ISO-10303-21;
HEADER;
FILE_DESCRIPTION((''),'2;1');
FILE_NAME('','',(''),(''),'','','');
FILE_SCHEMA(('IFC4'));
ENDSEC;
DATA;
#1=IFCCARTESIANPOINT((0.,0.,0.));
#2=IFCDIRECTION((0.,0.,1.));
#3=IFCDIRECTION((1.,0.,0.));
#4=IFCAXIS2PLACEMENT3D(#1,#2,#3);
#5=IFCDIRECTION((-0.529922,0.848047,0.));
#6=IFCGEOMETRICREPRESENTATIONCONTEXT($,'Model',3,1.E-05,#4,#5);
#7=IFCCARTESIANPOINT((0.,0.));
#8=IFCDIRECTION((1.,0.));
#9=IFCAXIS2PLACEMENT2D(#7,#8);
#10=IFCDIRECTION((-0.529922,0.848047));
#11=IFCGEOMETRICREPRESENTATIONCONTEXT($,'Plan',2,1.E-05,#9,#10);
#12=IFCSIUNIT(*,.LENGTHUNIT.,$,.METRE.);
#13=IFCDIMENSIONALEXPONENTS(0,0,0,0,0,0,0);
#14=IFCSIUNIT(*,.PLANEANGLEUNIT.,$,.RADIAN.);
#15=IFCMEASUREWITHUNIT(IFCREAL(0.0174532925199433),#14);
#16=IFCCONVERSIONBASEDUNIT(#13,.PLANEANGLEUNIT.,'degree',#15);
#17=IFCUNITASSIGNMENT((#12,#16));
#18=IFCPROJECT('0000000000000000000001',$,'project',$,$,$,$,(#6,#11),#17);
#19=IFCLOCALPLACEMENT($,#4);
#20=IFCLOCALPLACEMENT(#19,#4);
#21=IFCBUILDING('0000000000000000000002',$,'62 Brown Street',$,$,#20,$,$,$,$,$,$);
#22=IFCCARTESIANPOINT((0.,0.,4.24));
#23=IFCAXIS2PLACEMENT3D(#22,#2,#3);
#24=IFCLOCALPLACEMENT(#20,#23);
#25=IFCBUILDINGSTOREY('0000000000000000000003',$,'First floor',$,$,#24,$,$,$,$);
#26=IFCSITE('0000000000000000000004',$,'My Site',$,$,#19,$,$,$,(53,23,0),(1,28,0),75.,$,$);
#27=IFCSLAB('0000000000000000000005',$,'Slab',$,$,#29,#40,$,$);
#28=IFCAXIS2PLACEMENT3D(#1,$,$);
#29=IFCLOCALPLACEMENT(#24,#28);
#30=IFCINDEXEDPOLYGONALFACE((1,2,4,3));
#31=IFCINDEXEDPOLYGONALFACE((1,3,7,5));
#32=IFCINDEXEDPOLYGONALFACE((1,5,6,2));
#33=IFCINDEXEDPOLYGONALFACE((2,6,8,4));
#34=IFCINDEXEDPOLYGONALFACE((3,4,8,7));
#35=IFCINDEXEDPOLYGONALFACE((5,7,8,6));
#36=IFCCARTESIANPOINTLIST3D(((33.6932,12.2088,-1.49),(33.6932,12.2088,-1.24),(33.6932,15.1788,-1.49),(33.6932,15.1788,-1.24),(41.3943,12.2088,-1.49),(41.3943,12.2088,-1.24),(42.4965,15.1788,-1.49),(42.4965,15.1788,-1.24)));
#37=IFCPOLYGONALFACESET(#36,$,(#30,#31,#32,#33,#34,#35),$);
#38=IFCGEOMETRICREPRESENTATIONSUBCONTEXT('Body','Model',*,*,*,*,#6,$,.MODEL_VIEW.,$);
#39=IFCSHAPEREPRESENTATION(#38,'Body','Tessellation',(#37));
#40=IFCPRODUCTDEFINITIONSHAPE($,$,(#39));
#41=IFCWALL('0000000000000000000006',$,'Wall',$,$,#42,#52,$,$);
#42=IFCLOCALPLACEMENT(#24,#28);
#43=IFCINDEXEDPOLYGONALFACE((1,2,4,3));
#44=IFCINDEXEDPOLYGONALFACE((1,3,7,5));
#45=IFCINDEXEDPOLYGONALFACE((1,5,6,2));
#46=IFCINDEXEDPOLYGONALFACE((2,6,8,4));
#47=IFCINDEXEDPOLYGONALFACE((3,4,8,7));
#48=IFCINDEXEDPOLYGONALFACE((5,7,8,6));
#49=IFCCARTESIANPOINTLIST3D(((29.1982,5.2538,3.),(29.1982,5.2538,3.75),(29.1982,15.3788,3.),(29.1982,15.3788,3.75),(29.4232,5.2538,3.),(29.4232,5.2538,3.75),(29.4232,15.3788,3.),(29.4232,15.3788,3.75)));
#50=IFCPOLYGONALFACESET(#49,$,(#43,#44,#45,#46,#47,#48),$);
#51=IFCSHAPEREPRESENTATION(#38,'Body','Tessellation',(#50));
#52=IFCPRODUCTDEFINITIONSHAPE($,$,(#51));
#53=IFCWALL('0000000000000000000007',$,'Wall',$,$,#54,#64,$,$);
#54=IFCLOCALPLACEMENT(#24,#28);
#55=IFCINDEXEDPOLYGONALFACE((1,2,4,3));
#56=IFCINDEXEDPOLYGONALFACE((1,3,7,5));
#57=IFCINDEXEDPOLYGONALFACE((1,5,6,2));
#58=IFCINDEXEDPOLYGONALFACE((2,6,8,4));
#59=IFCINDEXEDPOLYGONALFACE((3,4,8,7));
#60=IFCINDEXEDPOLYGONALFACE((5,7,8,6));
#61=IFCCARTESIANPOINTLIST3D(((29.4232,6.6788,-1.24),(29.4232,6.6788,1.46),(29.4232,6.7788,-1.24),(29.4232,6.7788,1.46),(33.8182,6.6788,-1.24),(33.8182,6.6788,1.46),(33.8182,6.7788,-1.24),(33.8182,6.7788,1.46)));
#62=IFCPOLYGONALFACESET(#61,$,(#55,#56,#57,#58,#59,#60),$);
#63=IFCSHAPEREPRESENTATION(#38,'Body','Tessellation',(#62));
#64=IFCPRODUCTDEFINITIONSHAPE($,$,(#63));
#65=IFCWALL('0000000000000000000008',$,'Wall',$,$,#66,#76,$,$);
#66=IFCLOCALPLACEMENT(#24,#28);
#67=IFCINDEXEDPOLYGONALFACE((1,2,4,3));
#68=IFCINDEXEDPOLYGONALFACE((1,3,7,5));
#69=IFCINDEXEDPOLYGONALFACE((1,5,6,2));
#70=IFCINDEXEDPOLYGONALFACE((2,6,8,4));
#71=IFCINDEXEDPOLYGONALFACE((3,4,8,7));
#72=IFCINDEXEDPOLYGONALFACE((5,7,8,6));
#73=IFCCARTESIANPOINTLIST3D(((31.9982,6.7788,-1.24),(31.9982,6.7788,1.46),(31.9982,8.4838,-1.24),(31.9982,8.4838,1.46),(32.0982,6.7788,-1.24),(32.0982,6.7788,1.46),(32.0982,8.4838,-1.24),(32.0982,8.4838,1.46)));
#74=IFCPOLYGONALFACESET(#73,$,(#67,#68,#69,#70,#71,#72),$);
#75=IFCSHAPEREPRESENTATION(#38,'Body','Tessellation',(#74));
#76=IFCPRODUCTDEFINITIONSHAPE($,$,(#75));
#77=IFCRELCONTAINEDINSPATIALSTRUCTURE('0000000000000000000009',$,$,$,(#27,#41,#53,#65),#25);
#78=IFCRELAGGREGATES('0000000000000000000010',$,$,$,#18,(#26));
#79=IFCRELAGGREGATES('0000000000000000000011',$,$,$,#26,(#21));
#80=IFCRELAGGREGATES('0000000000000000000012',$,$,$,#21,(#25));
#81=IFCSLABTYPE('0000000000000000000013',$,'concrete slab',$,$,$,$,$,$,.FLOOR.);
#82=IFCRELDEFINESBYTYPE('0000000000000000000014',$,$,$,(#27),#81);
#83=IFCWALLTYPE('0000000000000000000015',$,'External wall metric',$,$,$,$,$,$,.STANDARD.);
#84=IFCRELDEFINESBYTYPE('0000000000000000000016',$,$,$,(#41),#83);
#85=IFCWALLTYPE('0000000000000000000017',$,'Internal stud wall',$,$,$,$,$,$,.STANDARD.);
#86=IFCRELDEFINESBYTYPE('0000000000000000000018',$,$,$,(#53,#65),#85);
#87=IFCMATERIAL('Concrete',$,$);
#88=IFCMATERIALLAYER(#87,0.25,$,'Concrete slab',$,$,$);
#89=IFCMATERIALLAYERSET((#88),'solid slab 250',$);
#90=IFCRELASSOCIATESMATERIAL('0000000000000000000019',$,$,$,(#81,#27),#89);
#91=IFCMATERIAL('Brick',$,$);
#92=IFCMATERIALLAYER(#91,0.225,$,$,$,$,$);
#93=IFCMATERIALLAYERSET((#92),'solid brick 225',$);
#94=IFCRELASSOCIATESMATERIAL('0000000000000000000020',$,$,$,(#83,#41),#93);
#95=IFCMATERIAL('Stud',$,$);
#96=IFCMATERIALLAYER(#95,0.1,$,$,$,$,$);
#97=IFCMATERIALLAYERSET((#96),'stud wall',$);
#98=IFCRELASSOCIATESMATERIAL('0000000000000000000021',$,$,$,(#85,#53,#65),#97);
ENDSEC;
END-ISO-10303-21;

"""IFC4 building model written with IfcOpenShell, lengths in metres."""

from ifc_helpers import new_model, entity, si_unit, converted_unit, direction, frame, origin_with_axes, origin_2d_with_axis, place, context, subcontext, project, spatial, line, indexed_curve, outline, extrude, material, layer, layer_set, layer_usage, type_object, element, save


model = new_model("IFC4")

# Units and contexts
model_context = context("Model", 3, precision=1e-05, world=origin_with_axes(), true_north=direction((-0.529922, 0.848047, 0.0)))
plan_context = context("Plan", 2, precision=1e-05, world=origin_2d_with_axis(), true_north=direction((-0.529922, 0.848047)))
body_context_1 = subcontext(model_context, "Body", "Model", "MODEL_VIEW")
ifc_project = project(units=[si_unit("LENGTHUNIT", "METRE"), converted_unit("PLANEANGLEUNIT", "degree", entity("IfcReal", 0.0174532925199433), si_unit("PLANEANGLEUNIT", "RADIAN"), dimensions=[0, 0, 0, 0, 0, 0, 0])], contexts=[model_context, plan_context])

# Site, building, storey
site_placement = place(None, origin_with_axes())
site = spatial("IfcSite", under=ifc_project, at=site_placement, Name="My Site", RefLatitude=(53, 23, 0), RefLongitude=(1, 28, 0), RefElevation=75.0)
building_placement = place(site_placement, origin_with_axes())
building = spatial("IfcBuilding", under=site, at=building_placement, Name="62 Brown Street")
storey_placement = place(building_placement, frame((0.0, 0.0, 4.24), z_axis=(0.0, 0.0, 1.0), x_axis=(1.0, 0.0, 0.0)))
storey = spatial("IfcBuildingStorey", under=building, at=storey_placement, Name="First floor")

# Shared definitions
ifc_material_1 = material(Name="Concrete")

# Slab
ifc_layer_1 = layer(ifc_material_1, 0.25, Name="Concrete slab")
ifc_layer_set_1 = layer_set([ifc_layer_1], Name="solid slab 250")
ifc_layer_usage_1 = layer_usage(ifc_layer_set_1, "AXIS3", "POSITIVE", 0.0)
slab_type = type_object("IfcSlabType", Name="concrete slab", PredefinedType="FLOOR", material=ifc_layer_set_1)
slab_1_placement = place(storey_placement, frame((33.6932, 12.2088, -1.49), z_axis=(0.0, 0.0, 1.0), x_axis=(1.0, 0.0, 0.0)))
element("IfcSlab", 1, at=slab_1_placement, inside=storey, type_object=slab_type, material=ifc_layer_usage_1, Name="Slab", context=body_context_1, shape_type="SweptSolid", body=[
    extrude(outline(indexed_curve([(8.8033, 2.97), (7.7011, 0.0), (0.0, 0.0), (0.0, 2.97)], segments=[line(4, 1), line(1, 2), line(2, 3), line(3, 4)], self_intersect=False)), None, (0.0, 0.0, 1.0), 0.25),
])

# Shared definitions
ifc_material_2 = material(Name="Brick")
ifc_layer_2 = layer(ifc_material_2, 0.225)
ifc_layer_set_2 = layer_set([ifc_layer_2], Name="solid brick 225")
wall_type_1 = type_object("IfcWallType", Name="External wall metric", PredefinedType="STANDARD", material=ifc_layer_set_2)

# Wall
ifc_layer_usage_2 = layer_usage(ifc_layer_set_2, "AXIS2", "POSITIVE", 0.0)
wall_1_placement = place(storey_placement, frame((29.4232, 5.2538, 3.0), z_axis=(0.0, 0.0, 1.0), x_axis=(0.0, 1.0, 0.0)))
element("IfcWall", 2, at=wall_1_placement, inside=storey, type_object=wall_type_1, material=ifc_layer_usage_2, Name="Wall", context=body_context_1, shape_type="SweptSolid", body=[
    extrude(outline(indexed_curve([(0.0, 0.0), (0.0, 0.225), (10.125, 0.225), (10.125, 0.0), (0.0, 0.0)], self_intersect=False)), origin_with_axes(), (0.0, 0.0, 1.0), 0.75),
])

# Shared definitions
ifc_material_3 = material(Name="Stud")
ifc_layer_3 = layer(ifc_material_3, 0.1)
ifc_layer_set_3 = layer_set([ifc_layer_3], Name="stud wall")
wall_type_2 = type_object("IfcWallType", Name="Internal stud wall", PredefinedType="STANDARD", material=ifc_layer_set_3)

# Walls
ifc_layer_usage_3 = layer_usage(ifc_layer_set_3, "AXIS2", "POSITIVE", 0.0)
wall_2_placement = place(storey_placement, frame((33.8182, 6.7788, -1.24), z_axis=(0.0, 0.0, 1.0), x_axis=(-1.0, 0.000001, 0.0)))
element("IfcWall", 3, at=wall_2_placement, inside=storey, type_object=wall_type_2, material=ifc_layer_usage_3, Name="Wall", context=body_context_1, shape_type="SweptSolid", body=[
    extrude(outline(indexed_curve([(0.0, 0.0), (0.0, 0.1), (4.395, 0.1), (4.395, 0.0), (0.0, 0.0)], self_intersect=False)), origin_with_axes(), (0.0, 0.0, 1.0), 2.7),
])
ifc_layer_usage_4 = layer_usage(ifc_layer_set_3, "AXIS2", "POSITIVE", 0.0)
wall_3_placement = place(storey_placement, frame((32.0982, 6.7788, -1.24), z_axis=(0.0, 0.0, 1.0), x_axis=(0.000001, 1.0, 0.0)))
element("IfcWall", 4, at=wall_3_placement, inside=storey, type_object=wall_type_2, material=ifc_layer_usage_4, Name="Wall", context=body_context_1, shape_type="SweptSolid", body=[
    extrude(outline(indexed_curve([(0.0, 0.0), (0.0, 0.1), (1.705, 0.1), (1.705, 0.0), (0.0, 0.0)], self_intersect=False)), origin_with_axes(), (0.0, 0.0, 1.0), 2.7),
])

save(model, "model.ifc")
